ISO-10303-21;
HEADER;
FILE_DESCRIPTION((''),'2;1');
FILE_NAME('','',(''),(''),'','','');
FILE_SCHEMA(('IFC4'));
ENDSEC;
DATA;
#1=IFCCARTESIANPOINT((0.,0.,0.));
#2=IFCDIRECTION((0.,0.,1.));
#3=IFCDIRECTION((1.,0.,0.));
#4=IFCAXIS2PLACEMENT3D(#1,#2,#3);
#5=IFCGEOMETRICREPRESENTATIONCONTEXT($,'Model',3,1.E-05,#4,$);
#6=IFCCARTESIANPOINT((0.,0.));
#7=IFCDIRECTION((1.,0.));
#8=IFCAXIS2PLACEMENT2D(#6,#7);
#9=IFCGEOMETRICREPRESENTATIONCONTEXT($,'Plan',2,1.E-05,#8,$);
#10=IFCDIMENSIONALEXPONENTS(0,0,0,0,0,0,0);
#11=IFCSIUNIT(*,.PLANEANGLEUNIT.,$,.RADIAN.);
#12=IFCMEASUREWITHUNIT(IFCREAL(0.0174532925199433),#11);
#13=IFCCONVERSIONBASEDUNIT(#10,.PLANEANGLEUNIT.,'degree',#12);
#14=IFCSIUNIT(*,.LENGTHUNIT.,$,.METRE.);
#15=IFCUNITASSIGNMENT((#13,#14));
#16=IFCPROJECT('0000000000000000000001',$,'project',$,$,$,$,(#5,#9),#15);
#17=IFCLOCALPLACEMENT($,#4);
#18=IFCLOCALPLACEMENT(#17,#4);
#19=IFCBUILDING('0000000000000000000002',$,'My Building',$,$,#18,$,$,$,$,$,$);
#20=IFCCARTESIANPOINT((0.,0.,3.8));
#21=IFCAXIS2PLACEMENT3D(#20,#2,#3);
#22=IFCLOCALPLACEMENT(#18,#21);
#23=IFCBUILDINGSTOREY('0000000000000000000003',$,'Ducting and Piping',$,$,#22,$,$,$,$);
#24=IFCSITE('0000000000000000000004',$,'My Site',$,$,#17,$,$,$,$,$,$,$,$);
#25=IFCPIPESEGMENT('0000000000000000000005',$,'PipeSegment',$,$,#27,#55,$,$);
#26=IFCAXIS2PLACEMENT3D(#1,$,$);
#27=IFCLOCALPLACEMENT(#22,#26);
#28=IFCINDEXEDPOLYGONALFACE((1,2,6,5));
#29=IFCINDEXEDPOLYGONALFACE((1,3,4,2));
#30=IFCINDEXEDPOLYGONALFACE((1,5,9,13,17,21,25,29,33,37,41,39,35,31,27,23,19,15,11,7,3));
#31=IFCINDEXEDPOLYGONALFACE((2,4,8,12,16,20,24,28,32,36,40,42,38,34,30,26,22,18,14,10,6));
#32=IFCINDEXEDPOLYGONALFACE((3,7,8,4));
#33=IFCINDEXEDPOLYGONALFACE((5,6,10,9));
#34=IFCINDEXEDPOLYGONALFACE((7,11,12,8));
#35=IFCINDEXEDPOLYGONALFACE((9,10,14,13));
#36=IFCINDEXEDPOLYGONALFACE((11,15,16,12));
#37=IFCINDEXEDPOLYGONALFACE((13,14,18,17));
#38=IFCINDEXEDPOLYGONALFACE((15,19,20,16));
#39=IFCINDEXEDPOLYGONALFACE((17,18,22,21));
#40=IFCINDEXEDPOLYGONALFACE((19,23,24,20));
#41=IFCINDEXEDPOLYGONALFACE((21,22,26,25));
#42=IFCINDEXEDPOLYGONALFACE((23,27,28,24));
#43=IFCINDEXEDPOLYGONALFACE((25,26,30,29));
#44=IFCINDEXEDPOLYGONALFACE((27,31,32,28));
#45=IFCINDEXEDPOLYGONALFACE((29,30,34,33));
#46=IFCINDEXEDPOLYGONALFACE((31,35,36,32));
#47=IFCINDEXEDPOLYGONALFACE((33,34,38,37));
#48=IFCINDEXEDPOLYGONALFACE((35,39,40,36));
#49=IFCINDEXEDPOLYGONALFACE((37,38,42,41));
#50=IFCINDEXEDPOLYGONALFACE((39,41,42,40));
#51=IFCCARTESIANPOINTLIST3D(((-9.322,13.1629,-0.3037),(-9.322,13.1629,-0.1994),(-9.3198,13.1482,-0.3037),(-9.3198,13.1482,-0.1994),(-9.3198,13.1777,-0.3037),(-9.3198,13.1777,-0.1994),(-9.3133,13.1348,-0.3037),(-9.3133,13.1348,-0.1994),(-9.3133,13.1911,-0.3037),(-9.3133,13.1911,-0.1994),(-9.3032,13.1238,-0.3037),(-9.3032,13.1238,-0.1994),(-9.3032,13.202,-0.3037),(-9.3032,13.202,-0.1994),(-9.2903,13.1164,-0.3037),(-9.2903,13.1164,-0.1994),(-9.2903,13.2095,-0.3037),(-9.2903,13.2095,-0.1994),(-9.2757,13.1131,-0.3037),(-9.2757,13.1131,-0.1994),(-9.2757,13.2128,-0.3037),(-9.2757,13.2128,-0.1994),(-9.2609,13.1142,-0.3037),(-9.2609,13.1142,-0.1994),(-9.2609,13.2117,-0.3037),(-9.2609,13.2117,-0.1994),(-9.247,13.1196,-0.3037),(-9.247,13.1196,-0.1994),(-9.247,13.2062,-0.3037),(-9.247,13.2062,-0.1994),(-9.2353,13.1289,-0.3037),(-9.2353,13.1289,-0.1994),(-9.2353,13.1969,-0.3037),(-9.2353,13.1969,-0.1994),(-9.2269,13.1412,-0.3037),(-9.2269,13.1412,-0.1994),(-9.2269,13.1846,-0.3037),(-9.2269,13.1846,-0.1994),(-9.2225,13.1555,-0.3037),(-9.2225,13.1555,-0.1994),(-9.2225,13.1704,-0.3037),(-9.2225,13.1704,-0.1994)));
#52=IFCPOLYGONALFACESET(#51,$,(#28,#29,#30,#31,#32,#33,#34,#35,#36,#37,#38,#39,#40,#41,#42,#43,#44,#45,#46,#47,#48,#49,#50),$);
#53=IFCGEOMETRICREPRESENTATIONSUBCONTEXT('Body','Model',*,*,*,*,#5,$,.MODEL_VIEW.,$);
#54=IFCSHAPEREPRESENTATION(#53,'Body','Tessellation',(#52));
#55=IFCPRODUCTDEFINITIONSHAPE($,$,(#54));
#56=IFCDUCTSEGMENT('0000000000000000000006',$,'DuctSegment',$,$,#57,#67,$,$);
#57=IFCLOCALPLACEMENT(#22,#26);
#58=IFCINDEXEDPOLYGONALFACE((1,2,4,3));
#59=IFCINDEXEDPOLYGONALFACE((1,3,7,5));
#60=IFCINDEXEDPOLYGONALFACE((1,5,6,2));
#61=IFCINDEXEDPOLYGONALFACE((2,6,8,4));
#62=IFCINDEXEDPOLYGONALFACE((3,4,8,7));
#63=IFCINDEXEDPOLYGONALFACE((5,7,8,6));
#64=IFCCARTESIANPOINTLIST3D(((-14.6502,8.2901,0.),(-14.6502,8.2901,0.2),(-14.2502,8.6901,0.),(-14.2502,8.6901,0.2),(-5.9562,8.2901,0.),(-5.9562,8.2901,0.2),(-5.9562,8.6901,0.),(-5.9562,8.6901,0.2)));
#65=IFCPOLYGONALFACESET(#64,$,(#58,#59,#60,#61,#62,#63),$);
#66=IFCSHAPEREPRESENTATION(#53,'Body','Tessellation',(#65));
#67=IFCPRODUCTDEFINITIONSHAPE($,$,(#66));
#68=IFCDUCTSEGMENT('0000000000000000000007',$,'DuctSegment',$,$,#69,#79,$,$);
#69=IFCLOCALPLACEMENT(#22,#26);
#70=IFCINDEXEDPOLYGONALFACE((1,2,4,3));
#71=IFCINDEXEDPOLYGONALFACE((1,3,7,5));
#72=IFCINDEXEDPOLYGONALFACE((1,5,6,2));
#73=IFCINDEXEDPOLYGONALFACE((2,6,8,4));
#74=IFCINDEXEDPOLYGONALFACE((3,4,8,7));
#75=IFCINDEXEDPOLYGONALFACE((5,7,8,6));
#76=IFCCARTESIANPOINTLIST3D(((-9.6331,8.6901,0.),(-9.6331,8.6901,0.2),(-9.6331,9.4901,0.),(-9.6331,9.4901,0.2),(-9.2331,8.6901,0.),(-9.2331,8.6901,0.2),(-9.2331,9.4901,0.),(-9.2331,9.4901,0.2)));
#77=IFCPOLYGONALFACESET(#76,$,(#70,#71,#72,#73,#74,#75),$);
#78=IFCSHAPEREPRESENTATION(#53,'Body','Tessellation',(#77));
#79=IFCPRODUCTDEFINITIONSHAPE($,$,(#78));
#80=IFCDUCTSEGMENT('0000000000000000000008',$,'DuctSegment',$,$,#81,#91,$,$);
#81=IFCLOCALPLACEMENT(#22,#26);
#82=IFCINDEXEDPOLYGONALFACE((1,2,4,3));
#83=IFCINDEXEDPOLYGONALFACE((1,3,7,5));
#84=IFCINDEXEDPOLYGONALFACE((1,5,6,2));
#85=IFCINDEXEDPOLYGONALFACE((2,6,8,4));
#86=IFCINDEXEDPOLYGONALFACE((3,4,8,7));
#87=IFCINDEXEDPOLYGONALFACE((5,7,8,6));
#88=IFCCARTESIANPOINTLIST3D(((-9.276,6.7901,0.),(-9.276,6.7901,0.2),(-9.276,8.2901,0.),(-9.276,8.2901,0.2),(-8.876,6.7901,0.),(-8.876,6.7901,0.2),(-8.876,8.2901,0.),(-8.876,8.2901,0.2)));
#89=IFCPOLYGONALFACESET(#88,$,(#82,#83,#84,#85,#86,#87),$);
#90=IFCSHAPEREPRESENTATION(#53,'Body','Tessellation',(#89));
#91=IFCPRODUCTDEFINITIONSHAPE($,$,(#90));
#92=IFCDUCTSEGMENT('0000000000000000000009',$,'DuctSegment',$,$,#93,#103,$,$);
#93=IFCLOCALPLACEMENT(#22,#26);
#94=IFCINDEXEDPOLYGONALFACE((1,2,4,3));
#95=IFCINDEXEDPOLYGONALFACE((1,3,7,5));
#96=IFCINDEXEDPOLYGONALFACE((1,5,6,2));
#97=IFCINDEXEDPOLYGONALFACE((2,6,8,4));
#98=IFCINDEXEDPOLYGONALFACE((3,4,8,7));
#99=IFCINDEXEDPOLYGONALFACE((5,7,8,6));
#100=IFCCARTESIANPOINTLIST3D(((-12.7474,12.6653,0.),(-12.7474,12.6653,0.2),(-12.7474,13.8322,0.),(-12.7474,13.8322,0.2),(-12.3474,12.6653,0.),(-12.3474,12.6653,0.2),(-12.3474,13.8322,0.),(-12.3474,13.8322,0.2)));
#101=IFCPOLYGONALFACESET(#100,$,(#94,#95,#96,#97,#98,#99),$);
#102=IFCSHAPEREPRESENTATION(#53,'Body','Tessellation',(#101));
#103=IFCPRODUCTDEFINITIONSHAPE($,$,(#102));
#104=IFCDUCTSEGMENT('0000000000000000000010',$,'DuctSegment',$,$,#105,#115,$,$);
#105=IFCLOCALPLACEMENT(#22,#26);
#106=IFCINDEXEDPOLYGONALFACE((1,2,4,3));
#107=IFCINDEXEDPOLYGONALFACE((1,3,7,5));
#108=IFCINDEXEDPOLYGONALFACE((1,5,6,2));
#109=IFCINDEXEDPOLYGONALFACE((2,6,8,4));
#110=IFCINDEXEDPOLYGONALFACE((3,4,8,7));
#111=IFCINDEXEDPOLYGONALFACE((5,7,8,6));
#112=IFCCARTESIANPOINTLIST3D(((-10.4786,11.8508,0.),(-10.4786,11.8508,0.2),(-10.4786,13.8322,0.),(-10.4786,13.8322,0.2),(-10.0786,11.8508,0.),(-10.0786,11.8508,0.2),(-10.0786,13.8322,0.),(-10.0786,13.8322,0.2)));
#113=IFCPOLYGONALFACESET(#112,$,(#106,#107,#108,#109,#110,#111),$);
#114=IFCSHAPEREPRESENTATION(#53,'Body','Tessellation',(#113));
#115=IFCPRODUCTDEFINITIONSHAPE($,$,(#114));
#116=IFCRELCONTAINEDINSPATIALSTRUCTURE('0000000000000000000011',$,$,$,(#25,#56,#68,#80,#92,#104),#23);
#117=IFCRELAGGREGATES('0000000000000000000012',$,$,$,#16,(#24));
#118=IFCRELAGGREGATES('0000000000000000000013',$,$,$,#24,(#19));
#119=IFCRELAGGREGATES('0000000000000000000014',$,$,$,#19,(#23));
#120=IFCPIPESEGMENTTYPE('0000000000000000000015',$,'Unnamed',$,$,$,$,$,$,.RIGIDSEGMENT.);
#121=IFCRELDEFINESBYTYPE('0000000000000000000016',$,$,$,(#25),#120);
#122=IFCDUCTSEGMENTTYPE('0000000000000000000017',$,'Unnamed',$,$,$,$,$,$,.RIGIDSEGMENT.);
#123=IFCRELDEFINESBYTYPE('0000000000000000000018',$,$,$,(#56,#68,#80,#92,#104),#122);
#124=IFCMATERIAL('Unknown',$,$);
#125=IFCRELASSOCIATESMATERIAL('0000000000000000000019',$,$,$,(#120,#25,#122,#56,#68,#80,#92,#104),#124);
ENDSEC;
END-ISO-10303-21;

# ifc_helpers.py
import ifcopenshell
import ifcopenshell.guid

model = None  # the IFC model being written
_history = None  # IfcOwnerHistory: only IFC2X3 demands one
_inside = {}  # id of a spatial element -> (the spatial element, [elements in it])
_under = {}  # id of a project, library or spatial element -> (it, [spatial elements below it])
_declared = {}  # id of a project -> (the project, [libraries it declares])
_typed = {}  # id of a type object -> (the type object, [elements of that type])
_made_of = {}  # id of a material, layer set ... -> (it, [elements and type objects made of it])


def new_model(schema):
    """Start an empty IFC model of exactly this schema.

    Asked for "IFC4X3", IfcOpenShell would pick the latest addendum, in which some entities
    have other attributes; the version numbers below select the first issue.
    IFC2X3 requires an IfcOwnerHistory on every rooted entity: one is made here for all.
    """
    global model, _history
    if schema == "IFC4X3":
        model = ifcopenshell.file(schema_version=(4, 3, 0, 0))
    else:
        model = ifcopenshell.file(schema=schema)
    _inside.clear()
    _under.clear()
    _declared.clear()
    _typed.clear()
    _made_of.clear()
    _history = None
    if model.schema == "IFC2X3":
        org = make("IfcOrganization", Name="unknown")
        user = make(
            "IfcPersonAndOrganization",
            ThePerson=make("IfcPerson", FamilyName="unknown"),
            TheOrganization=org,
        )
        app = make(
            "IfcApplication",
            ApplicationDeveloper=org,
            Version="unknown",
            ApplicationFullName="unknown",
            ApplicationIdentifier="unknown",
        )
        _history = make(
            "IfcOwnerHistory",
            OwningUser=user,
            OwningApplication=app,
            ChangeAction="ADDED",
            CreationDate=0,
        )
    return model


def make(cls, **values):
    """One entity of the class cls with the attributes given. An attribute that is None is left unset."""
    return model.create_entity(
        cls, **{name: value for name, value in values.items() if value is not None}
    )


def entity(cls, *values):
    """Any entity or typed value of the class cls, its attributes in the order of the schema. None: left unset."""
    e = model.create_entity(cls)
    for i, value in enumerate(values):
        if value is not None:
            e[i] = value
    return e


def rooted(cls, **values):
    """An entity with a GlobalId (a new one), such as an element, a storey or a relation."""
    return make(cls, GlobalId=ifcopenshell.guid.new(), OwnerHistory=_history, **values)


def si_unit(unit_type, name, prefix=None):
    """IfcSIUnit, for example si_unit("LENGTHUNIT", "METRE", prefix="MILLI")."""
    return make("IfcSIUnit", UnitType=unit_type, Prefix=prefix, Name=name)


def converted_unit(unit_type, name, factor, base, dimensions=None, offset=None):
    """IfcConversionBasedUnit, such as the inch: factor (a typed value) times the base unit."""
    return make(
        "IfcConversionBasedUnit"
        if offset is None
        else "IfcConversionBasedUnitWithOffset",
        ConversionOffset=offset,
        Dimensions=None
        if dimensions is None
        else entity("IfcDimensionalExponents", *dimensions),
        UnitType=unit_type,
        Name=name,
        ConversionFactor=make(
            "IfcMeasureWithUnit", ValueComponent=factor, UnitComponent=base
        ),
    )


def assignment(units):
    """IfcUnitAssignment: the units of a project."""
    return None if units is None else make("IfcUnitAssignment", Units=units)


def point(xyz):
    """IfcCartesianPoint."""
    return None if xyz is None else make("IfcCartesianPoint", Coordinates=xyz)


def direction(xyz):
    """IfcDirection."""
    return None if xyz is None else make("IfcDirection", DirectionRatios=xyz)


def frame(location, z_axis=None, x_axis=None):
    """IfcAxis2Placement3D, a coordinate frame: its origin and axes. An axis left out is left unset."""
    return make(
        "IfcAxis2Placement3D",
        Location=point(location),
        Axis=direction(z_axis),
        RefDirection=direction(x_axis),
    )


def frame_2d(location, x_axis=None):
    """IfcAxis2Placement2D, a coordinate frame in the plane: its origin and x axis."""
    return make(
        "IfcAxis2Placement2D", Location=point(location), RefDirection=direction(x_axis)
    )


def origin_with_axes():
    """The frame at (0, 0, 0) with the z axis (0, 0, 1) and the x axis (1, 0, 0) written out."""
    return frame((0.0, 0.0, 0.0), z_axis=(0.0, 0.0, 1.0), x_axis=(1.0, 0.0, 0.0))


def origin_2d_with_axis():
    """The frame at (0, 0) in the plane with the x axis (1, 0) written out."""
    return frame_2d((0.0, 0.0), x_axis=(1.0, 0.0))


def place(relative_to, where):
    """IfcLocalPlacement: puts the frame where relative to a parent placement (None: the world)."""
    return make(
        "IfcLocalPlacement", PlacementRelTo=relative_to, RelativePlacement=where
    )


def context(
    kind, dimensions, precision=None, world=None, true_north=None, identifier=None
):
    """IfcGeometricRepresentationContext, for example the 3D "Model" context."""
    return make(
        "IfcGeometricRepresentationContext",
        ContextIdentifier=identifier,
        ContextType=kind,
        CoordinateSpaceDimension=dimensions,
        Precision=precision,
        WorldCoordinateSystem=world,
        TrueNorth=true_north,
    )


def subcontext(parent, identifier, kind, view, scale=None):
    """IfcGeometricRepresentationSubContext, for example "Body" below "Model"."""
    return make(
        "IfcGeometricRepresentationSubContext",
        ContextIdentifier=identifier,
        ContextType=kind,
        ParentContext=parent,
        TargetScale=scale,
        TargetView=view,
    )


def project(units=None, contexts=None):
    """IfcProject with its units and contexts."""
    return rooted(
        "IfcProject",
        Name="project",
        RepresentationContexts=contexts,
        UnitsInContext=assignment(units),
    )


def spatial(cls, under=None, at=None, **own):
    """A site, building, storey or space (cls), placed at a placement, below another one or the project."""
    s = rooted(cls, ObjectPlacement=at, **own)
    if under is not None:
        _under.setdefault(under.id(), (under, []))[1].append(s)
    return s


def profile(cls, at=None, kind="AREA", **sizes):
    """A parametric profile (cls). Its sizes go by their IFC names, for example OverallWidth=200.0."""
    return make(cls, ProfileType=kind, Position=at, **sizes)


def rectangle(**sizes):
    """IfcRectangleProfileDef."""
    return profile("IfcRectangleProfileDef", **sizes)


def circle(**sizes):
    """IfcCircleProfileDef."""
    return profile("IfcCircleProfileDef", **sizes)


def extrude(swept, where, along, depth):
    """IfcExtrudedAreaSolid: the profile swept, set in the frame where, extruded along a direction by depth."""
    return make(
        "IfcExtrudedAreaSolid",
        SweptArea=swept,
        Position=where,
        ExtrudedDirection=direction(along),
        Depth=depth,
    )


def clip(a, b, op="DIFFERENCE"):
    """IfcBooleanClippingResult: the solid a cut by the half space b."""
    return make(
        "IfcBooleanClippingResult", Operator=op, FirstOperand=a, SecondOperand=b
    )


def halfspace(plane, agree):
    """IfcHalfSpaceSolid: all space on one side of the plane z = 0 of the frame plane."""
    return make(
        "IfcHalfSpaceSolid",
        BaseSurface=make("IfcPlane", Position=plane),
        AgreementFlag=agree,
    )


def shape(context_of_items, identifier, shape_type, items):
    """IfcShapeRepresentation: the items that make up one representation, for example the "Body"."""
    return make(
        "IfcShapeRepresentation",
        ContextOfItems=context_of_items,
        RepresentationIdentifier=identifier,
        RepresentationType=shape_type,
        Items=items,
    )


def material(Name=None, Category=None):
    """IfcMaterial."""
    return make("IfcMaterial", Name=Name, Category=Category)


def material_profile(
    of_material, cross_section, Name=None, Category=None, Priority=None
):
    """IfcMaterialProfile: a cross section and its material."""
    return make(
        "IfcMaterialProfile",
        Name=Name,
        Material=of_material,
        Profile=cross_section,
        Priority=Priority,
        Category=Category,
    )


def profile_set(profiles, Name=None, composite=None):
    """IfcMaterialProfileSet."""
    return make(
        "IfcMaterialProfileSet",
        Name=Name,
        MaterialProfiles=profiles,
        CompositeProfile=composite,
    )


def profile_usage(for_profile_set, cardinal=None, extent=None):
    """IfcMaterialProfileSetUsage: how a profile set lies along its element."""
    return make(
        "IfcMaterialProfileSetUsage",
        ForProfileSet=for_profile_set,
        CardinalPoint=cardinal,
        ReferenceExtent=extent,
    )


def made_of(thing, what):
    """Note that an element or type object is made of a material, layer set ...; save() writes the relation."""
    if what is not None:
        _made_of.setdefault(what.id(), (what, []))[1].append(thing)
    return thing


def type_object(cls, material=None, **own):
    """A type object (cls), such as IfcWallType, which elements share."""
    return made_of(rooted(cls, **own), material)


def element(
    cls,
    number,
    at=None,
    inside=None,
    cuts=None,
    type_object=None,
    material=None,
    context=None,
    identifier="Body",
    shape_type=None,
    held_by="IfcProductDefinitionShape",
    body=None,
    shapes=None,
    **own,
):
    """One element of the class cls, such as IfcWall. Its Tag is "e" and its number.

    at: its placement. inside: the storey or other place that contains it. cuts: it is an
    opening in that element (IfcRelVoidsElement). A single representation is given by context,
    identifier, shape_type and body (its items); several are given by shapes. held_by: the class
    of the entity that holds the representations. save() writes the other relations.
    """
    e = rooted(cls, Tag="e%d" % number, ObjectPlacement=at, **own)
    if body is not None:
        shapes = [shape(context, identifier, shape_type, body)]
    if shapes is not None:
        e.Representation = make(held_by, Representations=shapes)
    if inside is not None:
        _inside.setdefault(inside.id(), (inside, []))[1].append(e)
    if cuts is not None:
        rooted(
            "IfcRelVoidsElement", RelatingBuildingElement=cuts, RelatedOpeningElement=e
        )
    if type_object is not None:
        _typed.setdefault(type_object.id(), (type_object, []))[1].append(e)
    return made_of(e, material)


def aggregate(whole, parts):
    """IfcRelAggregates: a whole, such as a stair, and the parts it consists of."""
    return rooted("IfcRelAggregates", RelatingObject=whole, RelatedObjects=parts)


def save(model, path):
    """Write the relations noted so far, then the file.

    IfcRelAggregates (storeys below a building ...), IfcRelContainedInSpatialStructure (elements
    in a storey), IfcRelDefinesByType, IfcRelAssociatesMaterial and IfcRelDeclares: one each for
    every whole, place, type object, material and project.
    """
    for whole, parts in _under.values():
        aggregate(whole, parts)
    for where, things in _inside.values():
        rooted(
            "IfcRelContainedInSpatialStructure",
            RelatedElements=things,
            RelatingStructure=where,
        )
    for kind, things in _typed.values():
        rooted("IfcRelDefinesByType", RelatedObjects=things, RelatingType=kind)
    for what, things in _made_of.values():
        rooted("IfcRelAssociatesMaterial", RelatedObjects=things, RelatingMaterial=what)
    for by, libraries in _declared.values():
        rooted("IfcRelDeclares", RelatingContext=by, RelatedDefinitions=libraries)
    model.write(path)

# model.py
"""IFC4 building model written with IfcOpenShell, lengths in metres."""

from ifc_helpers import new_model, entity, si_unit, converted_unit, frame, origin_with_axes, origin_2d_with_axis, place, context, subcontext, project, spatial, rectangle, circle, extrude, clip, halfspace, material, material_profile, profile_set, profile_usage, type_object, element, save


model = new_model("IFC4")

# Units and contexts
model_context = context("Model", 3, precision=1e-05, world=origin_with_axes())
plan_context = context("Plan", 2, precision=1e-05, world=origin_2d_with_axis())
body_context = subcontext(model_context, "Body", "Model", "MODEL_VIEW")
ifc_project = project(units=[converted_unit("PLANEANGLEUNIT", "degree", entity("IfcReal", 0.0174532925199433), si_unit("PLANEANGLEUNIT", "RADIAN"), dimensions=[0, 0, 0, 0, 0, 0, 0]), si_unit("LENGTHUNIT", "METRE")], contexts=[model_context, plan_context])

# Site, building, storey
site_placement = place(None, origin_with_axes())
site = spatial("IfcSite", under=ifc_project, at=site_placement, Name="My Site")
building_placement = place(site_placement, origin_with_axes())
building = spatial("IfcBuilding", under=site, at=building_placement, Name="My Building")
storey_placement = place(building_placement, frame((0.0, 0.0, 3.8), z_axis=(0.0, 0.0, 1.0), x_axis=(1.0, 0.0, 0.0)))
storey = spatial("IfcBuildingStorey", under=building, at=storey_placement, Name="Ducting and Piping")

# Pipe segment
ifc_material = material(Name="Unknown")
ifc_material_profile_1 = material_profile(ifc_material, circle(Radius=0.05))
ifc_profile_set_1 = profile_set([ifc_material_profile_1])
pipe_segment_type = type_object("IfcPipeSegmentType", Name="Unnamed", PredefinedType="RIGIDSEGMENT", material=ifc_profile_set_1)
ifc_profile_usage_1 = profile_usage(ifc_profile_set_1, cardinal=5)
pipe_segment_1_placement = place(storey_placement, frame((-9.272, 13.1629, -0.3037), z_axis=(0.0, 0.0, 1.0), x_axis=(-1.0, 0.0, 0.0)))
element("IfcPipeSegment", 1, at=pipe_segment_1_placement, inside=storey, type_object=pipe_segment_type, material=ifc_profile_usage_1, Name="PipeSegment", context=body_context, shape_type="SweptSolid", body=[
    extrude(circle(Radius=0.05), origin_with_axes(), (0.0, 0.0, 1.0), 0.1043),
])

# Duct segments
ifc_material_profile_2 = material_profile(ifc_material, rectangle(XDim=0.4, YDim=0.2))
ifc_profile_set_2 = profile_set([ifc_material_profile_2])
ifc_profile_usage_2 = profile_usage(ifc_profile_set_2, cardinal=5)
duct_segment_type = type_object("IfcDuctSegmentType", Name="Unnamed", PredefinedType="RIGIDSEGMENT", material=ifc_profile_set_2)
duct_segment_1_placement = place(storey_placement, frame((-5.9562, 8.4901, 0.1), z_axis=(-1.0, 0.0, 0.0), x_axis=(0.0, -1.0, 0.0)))
element("IfcDuctSegment", 2, at=duct_segment_1_placement, inside=storey, type_object=duct_segment_type, material=ifc_profile_usage_2, Name="DuctSegment", context=body_context, shape_type="Clipping", body=[
    clip(extrude(rectangle(XDim=0.4, YDim=0.2), origin_with_axes(), (0.0, 0.0, 1.0), 8.6941), halfspace(frame((0.2, 0.0, 8.6941), z_axis=(-0.707107, 0.0, 0.707107), x_axis=(0.0, 1.0, 0.0)), False)),
])
ifc_profile_usage_3 = profile_usage(ifc_profile_set_2, cardinal=5)
duct_segment_2_placement = place(storey_placement, frame((-9.4331, 8.6901, 0.1), z_axis=(0.0, 1.0, 0.0), x_axis=(-1.0, 0.0, 0.0)))
element("IfcDuctSegment", 3, at=duct_segment_2_placement, inside=storey, type_object=duct_segment_type, material=ifc_profile_usage_3, Name="DuctSegment", context=body_context, shape_type="SweptSolid", body=[
    extrude(rectangle(XDim=0.4, YDim=0.2), origin_with_axes(), (0.0, 0.0, 1.0), 0.8),
])
ifc_profile_usage_4 = profile_usage(ifc_profile_set_2, cardinal=5)
duct_segment_3_placement = place(storey_placement, frame((-9.076, 8.2901, 0.1), z_axis=(0.0, -1.0, 0.0), x_axis=(1.0, 0.0, 0.0)))
element("IfcDuctSegment", 4, at=duct_segment_3_placement, inside=storey, type_object=duct_segment_type, material=ifc_profile_usage_4, Name="DuctSegment", context=body_context, shape_type="SweptSolid", body=[
    extrude(rectangle(XDim=0.4, YDim=0.2), origin_with_axes(), (0.0, 0.0, 1.0), 1.5),
])
ifc_profile_usage_5 = profile_usage(ifc_profile_set_2, cardinal=5)
duct_segment_4_placement = place(storey_placement, frame((-12.5474, 13.8322, 0.1), z_axis=(0.0, -1.0, 0.0), x_axis=(1.0, 0.0, 0.0)))
element("IfcDuctSegment", 5, at=duct_segment_4_placement, inside=storey, type_object=duct_segment_type, material=ifc_profile_usage_5, Name="DuctSegment", context=body_context, shape_type="SweptSolid", body=[
    extrude(rectangle(XDim=0.4, YDim=0.2), origin_with_axes(), (0.0, 0.0, 1.0), 1.1669),
])
ifc_profile_usage_6 = profile_usage(ifc_profile_set_2, cardinal=5)
duct_segment_5_placement = place(storey_placement, frame((-10.2786, 13.8322, 0.1), z_axis=(0.0, -1.0, 0.0), x_axis=(1.0, 0.0, 0.0)))
element("IfcDuctSegment", 6, at=duct_segment_5_placement, inside=storey, type_object=duct_segment_type, material=ifc_profile_usage_6, Name="DuctSegment", context=body_context, shape_type="SweptSolid", body=[
    extrude(rectangle(XDim=0.4, YDim=0.2), origin_with_axes(), (0.0, 0.0, 1.0), 1.9814),
])

save(model, "model.ifc")
